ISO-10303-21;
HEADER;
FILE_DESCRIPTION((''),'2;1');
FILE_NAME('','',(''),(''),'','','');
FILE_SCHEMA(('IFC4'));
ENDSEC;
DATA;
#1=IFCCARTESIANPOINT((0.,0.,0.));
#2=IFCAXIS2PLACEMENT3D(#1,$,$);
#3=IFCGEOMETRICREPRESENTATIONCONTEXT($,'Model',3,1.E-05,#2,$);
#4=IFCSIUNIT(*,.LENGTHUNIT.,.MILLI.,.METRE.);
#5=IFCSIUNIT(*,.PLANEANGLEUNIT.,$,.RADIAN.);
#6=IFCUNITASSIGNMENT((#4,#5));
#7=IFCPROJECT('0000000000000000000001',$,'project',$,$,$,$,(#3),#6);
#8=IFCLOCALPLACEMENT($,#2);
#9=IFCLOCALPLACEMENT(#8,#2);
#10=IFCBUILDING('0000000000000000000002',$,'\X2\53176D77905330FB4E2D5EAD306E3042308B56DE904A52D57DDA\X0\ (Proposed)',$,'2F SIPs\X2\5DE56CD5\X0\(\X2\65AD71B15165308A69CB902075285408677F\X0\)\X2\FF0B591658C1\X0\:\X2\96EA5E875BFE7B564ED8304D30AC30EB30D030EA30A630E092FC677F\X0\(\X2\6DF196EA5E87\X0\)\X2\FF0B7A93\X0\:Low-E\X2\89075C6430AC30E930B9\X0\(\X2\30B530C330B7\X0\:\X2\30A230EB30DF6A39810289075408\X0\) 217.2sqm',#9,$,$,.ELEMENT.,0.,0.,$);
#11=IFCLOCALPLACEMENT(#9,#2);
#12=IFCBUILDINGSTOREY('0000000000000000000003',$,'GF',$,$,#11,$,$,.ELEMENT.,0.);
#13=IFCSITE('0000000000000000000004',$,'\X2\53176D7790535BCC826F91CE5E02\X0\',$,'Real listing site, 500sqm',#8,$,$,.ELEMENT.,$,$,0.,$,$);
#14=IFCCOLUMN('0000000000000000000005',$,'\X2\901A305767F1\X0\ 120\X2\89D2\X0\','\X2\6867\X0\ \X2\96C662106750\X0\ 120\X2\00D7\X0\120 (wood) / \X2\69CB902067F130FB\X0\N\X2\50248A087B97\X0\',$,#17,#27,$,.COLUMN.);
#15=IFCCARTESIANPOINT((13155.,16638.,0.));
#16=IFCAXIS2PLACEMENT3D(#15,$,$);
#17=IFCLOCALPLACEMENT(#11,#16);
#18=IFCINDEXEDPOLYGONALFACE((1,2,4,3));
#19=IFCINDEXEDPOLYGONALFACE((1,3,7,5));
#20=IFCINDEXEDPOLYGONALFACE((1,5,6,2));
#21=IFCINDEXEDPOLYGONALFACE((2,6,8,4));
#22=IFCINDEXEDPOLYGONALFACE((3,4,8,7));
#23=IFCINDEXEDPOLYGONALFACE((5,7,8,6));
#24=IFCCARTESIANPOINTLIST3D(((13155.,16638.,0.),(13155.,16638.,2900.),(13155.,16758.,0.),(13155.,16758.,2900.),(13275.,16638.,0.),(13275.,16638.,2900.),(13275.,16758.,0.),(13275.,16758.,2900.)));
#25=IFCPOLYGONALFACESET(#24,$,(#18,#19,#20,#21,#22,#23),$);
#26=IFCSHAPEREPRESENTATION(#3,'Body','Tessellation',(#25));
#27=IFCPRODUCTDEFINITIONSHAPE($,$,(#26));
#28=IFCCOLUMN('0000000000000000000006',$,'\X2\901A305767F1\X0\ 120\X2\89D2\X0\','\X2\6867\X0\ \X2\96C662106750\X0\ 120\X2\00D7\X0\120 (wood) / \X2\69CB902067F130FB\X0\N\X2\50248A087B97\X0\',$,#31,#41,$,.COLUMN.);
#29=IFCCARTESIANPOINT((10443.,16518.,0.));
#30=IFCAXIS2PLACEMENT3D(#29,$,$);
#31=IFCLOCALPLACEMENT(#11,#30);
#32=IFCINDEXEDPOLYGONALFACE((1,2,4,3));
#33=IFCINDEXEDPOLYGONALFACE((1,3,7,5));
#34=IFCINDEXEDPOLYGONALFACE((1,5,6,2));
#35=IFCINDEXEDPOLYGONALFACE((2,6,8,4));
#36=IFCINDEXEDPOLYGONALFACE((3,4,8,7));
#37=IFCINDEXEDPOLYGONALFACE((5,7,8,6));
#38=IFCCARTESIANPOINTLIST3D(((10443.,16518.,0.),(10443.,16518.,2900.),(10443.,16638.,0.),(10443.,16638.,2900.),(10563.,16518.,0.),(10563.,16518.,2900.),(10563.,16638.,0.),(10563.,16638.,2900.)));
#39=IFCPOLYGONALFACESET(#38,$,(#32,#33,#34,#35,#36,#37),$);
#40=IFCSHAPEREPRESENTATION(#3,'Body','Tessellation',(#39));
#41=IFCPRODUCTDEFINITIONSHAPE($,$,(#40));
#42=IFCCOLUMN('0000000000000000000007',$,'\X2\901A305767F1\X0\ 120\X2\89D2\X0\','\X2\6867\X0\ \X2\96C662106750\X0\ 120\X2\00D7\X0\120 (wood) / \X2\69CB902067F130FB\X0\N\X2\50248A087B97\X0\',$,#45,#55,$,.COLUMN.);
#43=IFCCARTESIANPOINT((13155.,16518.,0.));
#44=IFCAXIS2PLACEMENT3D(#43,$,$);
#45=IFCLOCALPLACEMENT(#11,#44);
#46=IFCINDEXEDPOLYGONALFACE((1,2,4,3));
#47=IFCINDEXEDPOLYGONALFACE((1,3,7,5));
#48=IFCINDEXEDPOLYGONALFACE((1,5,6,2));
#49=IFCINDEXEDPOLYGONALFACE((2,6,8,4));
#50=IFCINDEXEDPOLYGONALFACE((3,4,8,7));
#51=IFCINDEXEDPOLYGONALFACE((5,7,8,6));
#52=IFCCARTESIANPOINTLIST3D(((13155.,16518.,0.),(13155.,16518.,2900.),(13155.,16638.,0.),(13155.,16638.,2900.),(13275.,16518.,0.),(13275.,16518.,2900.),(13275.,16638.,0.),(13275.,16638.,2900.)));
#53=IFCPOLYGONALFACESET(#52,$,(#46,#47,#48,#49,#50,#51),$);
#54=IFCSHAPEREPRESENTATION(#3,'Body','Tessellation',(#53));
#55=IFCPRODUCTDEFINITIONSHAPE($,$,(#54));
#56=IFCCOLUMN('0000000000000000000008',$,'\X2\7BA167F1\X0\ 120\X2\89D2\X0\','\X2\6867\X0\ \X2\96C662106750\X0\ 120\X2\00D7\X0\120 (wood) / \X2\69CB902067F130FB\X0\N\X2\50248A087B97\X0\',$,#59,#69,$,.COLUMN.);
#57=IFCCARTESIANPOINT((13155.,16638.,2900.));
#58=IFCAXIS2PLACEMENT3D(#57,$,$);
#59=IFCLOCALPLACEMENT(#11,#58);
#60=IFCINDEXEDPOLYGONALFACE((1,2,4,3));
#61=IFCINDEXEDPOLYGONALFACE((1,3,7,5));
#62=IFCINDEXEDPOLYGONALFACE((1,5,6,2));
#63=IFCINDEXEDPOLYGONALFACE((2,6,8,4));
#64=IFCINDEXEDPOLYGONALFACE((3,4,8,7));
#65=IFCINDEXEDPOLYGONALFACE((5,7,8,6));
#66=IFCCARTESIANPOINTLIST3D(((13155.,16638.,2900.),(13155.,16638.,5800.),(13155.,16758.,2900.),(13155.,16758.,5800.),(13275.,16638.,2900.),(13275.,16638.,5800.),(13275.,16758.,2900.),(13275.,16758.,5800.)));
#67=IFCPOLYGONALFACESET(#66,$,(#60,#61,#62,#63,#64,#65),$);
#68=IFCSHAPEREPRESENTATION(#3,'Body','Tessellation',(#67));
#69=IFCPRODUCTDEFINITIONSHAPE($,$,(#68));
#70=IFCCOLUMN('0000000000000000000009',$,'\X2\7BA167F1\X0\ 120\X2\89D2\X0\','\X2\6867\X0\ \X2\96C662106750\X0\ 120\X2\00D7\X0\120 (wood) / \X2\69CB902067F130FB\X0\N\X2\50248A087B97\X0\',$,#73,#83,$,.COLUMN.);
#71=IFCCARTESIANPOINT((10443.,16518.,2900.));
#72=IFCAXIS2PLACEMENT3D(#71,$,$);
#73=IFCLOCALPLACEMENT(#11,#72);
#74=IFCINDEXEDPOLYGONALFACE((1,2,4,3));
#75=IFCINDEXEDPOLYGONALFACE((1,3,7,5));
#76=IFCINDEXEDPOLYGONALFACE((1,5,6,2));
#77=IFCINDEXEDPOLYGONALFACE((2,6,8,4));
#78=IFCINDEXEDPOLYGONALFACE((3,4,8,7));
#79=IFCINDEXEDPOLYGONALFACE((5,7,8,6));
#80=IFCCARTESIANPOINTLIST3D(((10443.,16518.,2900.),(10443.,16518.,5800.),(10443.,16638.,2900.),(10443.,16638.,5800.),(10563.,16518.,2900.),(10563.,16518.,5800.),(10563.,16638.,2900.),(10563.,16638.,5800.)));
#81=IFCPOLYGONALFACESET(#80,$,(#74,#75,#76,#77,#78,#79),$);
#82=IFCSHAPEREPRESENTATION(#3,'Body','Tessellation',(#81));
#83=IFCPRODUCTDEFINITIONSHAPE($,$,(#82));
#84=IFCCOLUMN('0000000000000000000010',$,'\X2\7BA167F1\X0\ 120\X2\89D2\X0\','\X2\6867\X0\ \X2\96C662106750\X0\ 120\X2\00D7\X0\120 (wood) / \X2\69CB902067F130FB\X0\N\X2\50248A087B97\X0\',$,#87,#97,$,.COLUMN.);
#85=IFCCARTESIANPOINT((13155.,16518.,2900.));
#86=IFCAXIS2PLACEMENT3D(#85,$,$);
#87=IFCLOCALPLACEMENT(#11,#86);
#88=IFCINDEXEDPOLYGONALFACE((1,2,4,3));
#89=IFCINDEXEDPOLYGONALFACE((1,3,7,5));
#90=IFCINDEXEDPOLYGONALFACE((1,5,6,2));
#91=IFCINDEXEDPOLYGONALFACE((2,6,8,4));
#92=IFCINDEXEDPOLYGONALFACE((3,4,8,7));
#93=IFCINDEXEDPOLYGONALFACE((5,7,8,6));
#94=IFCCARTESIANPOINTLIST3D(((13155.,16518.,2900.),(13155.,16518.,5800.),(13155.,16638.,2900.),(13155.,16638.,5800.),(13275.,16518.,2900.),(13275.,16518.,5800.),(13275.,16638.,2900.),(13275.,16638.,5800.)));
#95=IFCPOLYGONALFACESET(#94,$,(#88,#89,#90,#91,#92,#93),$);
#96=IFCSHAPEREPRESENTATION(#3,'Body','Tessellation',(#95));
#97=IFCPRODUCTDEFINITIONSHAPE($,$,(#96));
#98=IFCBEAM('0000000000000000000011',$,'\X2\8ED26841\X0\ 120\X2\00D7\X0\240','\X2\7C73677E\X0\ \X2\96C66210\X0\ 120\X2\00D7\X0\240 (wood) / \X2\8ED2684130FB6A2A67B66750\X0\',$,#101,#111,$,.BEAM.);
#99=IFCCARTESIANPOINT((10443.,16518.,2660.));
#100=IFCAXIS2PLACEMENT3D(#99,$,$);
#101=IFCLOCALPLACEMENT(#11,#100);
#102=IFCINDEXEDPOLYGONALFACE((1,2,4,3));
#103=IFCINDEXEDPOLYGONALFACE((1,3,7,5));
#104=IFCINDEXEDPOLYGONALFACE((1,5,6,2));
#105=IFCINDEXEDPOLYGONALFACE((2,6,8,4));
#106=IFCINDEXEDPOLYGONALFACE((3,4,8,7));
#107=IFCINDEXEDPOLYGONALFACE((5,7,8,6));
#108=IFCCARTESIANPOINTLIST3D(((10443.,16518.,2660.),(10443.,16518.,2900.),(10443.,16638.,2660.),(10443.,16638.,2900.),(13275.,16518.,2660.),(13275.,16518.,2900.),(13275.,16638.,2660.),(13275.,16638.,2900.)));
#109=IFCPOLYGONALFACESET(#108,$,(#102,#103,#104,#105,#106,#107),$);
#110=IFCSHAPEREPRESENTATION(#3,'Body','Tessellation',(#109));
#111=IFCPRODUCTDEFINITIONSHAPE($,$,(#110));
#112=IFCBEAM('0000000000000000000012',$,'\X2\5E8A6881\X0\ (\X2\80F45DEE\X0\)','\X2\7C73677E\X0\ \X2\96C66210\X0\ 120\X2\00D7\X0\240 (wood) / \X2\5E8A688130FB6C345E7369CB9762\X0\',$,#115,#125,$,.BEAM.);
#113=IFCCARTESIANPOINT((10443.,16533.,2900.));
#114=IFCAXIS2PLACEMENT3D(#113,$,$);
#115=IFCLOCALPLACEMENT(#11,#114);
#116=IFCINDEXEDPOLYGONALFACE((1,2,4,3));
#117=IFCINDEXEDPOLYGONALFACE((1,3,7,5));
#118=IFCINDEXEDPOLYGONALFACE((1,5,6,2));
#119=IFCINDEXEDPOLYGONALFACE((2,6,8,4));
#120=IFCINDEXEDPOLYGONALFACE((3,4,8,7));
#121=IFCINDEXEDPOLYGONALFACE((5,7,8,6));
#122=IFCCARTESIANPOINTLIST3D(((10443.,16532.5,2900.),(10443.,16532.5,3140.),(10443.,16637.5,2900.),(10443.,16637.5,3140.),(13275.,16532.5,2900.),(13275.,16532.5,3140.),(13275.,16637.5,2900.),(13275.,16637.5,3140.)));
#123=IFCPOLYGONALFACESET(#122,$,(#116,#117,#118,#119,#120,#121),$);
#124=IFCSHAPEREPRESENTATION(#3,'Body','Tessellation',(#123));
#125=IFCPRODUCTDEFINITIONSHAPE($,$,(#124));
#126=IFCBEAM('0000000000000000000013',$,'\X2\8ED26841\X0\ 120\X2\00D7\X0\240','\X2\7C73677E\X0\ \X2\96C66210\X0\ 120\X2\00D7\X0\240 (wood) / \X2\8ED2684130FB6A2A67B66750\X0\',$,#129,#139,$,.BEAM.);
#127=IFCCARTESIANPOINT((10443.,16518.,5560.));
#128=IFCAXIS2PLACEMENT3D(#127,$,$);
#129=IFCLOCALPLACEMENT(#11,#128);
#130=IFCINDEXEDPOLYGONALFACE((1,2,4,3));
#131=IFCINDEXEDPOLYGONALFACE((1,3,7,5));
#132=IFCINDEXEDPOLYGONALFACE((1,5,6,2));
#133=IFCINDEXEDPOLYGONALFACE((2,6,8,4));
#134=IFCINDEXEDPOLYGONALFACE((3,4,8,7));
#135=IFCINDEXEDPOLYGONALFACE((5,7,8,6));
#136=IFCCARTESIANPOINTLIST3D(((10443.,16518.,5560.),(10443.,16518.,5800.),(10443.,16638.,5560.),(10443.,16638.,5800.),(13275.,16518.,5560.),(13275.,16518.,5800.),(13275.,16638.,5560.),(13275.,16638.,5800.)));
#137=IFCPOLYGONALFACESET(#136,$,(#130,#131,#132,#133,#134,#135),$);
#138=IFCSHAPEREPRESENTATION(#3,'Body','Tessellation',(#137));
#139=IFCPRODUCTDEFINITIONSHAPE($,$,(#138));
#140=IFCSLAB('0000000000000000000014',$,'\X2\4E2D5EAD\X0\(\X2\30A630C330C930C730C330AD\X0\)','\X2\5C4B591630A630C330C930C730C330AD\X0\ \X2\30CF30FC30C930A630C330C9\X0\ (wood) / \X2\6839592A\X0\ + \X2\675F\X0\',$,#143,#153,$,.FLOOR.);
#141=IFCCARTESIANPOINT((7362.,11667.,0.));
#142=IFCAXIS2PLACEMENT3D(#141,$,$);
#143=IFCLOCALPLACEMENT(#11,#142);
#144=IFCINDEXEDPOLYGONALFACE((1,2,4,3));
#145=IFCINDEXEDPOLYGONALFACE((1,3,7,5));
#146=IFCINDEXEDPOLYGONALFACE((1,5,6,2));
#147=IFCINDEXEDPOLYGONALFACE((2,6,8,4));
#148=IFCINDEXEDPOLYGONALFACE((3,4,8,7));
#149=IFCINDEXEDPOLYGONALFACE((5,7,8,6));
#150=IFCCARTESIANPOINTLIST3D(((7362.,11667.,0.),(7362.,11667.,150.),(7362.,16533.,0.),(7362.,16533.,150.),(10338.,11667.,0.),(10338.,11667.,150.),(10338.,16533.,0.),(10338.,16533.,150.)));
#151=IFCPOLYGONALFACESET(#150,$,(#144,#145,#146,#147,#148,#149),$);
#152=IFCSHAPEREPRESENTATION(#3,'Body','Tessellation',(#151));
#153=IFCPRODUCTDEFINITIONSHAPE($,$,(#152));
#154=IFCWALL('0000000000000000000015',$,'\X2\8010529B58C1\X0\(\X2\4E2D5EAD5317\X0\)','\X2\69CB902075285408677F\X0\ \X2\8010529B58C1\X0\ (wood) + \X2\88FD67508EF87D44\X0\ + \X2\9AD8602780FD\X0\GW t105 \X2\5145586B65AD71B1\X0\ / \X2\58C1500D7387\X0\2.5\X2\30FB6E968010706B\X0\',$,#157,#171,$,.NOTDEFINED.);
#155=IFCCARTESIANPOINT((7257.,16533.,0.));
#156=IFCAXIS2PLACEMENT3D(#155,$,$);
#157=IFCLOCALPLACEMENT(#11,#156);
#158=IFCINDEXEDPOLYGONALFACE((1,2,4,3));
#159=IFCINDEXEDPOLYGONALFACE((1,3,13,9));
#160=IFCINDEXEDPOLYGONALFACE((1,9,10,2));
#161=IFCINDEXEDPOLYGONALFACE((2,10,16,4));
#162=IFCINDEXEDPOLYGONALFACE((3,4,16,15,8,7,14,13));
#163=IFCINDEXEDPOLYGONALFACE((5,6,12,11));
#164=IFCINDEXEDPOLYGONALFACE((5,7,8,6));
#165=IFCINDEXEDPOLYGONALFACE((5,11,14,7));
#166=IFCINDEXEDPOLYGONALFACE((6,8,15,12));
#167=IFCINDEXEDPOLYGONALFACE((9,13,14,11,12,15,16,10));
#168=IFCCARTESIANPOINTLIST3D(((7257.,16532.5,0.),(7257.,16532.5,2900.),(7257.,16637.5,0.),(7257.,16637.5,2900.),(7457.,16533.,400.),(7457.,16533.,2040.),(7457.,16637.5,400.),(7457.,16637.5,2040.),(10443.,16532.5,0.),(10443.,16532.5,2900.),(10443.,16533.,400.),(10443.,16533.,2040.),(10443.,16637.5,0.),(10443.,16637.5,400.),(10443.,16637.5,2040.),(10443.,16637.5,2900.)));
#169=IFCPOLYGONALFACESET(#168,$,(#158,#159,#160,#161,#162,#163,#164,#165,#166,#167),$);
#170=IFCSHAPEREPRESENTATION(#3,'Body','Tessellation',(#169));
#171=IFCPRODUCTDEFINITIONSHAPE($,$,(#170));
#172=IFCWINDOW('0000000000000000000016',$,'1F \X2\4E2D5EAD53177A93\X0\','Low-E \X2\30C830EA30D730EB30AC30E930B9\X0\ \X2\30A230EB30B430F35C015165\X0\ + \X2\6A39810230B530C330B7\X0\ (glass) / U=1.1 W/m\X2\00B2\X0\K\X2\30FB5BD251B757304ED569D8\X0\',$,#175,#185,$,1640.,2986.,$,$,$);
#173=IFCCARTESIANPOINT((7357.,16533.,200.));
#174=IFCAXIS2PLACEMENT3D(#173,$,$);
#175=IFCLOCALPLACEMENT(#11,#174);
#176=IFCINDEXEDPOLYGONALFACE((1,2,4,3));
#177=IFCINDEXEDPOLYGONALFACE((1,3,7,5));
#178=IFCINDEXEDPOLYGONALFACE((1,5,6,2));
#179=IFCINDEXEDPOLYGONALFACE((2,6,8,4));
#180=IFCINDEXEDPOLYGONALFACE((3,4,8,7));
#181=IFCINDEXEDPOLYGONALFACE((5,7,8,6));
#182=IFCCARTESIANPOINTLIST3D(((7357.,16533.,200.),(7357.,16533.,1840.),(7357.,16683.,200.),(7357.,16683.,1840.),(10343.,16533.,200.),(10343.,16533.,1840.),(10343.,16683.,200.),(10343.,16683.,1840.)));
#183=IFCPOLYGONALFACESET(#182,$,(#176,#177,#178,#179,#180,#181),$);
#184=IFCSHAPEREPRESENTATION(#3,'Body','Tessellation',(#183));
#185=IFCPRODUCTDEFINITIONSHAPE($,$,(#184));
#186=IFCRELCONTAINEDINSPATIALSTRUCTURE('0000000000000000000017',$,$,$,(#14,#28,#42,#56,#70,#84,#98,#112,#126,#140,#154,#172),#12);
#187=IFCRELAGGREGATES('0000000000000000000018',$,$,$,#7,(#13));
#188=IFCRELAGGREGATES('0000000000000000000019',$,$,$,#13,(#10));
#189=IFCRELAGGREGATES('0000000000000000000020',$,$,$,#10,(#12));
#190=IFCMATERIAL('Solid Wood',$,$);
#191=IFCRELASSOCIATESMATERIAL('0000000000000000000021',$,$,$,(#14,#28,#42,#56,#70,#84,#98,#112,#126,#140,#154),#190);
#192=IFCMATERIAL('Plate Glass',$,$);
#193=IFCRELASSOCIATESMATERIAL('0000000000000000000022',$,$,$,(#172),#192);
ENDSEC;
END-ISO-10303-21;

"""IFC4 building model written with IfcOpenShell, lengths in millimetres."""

from ifc_helpers import new_model, si_unit, frame, frame_2d, origin, place, context, project, spatial, rectangle, extrude, material, element, fill, save


model = new_model("IFC4")

# Units and contexts
model_context = context("Model", 3, precision=1e-05, world=origin())
ifc_project = project(units=[si_unit("LENGTHUNIT", "METRE", prefix="MILLI"), si_unit("PLANEANGLEUNIT", "RADIAN")], contexts=[model_context])

# Site, building, storey
site_placement = place(None, origin())
site = spatial("IfcSite", under=ifc_project, at=site_placement, Name="北海道富良野市", ObjectType="Real listing site, 500sqm", CompositionType="ELEMENT", RefElevation=0.0)
building_placement = place(site_placement, origin())
building = spatial("IfcBuilding", under=site, at=building_placement, Name="北海道・中庭のある回遊動線 (Proposed)", ObjectType="2F SIPs工法(断熱入り構造用合板)＋外壁:雪庇対策付きガルバリウム鋼板(深雪庇)＋窓:Low-E複層ガラス(サッシ:アルミ樹脂複合) 217.2sqm", CompositionType="ELEMENT", ElevationOfRefHeight=0.0, ElevationOfTerrain=0.0)
storey_placement = place(building_placement, origin())
storey = spatial("IfcBuildingStorey", under=building, at=storey_placement, Name="GF", CompositionType="ELEMENT", Elevation=0.0)

# Columns
ifc_material_1 = material(Name="Solid Wood")
column_1_placement = place(storey_placement, frame((13155.0, 16638.0, 0.0)))
element("IfcColumn", 1, at=column_1_placement, inside=storey, material=ifc_material_1, Name="通し柱 120角", Description="桧 集成材 120×120 (wood) / 構造柱・N値計算", PredefinedType="COLUMN", context=model_context, shape_type="SweptSolid", body=[
    extrude(rectangle(XDim=120.0, YDim=120.0, at=frame_2d((60.0, 60.0))), frame((13155.0, 16638.0, 0.0)), (0.0, 0.0, 1.0), 2900.0),
])
column_2_placement = place(storey_placement, frame((10443.0, 16518.0, 0.0)))
element("IfcColumn", 2, at=column_2_placement, inside=storey, material=ifc_material_1, Name="通し柱 120角", Description="桧 集成材 120×120 (wood) / 構造柱・N値計算", PredefinedType="COLUMN", context=model_context, shape_type="SweptSolid", body=[
    extrude(rectangle(XDim=120.0, YDim=120.0, at=frame_2d((60.0, 60.0))), frame((10443.0, 16518.0, 0.0)), (0.0, 0.0, 1.0), 2900.0),
])
column_3_placement = place(storey_placement, frame((13155.0, 16518.0, 0.0)))
element("IfcColumn", 3, at=column_3_placement, inside=storey, material=ifc_material_1, Name="通し柱 120角", Description="桧 集成材 120×120 (wood) / 構造柱・N値計算", PredefinedType="COLUMN", context=model_context, shape_type="SweptSolid", body=[
    extrude(rectangle(XDim=120.0, YDim=120.0, at=frame_2d((60.0, 60.0))), frame((13155.0, 16518.0, 0.0)), (0.0, 0.0, 1.0), 2900.0),
])
column_4_placement = place(storey_placement, frame((13155.0, 16638.0, 2900.0)))
element("IfcColumn", 4, at=column_4_placement, inside=storey, material=ifc_material_1, Name="管柱 120角", Description="桧 集成材 120×120 (wood) / 構造柱・N値計算", PredefinedType="COLUMN", context=model_context, shape_type="SweptSolid", body=[
    extrude(rectangle(XDim=120.0, YDim=120.0, at=frame_2d((60.0, 60.0))), frame((13155.0, 16638.0, 2900.0)), (0.0, 0.0, 1.0), 2900.0),
])
column_5_placement = place(storey_placement, frame((10443.0, 16518.0, 2900.0)))
element("IfcColumn", 5, at=column_5_placement, inside=storey, material=ifc_material_1, Name="管柱 120角", Description="桧 集成材 120×120 (wood) / 構造柱・N値計算", PredefinedType="COLUMN", context=model_context, shape_type="SweptSolid", body=[
    extrude(rectangle(XDim=120.0, YDim=120.0, at=frame_2d((60.0, 60.0))), frame((10443.0, 16518.0, 2900.0)), (0.0, 0.0, 1.0), 2900.0),
])
column_6_placement = place(storey_placement, frame((13155.0, 16518.0, 2900.0)))
element("IfcColumn", 6, at=column_6_placement, inside=storey, material=ifc_material_1, Name="管柱 120角", Description="桧 集成材 120×120 (wood) / 構造柱・N値計算", PredefinedType="COLUMN", context=model_context, shape_type="SweptSolid", body=[
    extrude(rectangle(XDim=120.0, YDim=120.0, at=frame_2d((60.0, 60.0))), frame((13155.0, 16518.0, 2900.0)), (0.0, 0.0, 1.0), 2900.0),
])

# Beams
beam_1_placement = place(storey_placement, frame((10443.0, 16518.0, 2660.0)))
element("IfcBeam", 7, at=beam_1_placement, inside=storey, material=ifc_material_1, Name="軒桁 120×240", Description="米松 集成 120×240 (wood) / 軒桁・横架材", PredefinedType="BEAM", context=model_context, shape_type="SweptSolid", body=[
    extrude(rectangle(XDim=2832.0, YDim=120.0, at=frame_2d((1416.0, 60.0))), frame((10443.0, 16518.0, 2660.0)), (0.0, 0.0, 1.0), 240.0),
])
beam_2_placement = place(storey_placement, frame((10443.0, 16533.0, 2900.0)))
element("IfcBeam", 8, at=beam_2_placement, inside=storey, material=ifc_material_1, Name="床梁 (胴差)", Description="米松 集成 120×240 (wood) / 床梁・水平構面", PredefinedType="BEAM", context=model_context, shape_type="SweptSolid", body=[
    extrude(rectangle(XDim=2832.0, YDim=105.0, at=frame_2d((1416.0, 52.0))), frame((10443.0, 16533.0, 2900.0)), (0.0, 0.0, 1.0), 240.0),
])
beam_3_placement = place(storey_placement, frame((10443.0, 16518.0, 5560.0)))
element("IfcBeam", 9, at=beam_3_placement, inside=storey, material=ifc_material_1, Name="軒桁 120×240", Description="米松 集成 120×240 (wood) / 軒桁・横架材", PredefinedType="BEAM", context=model_context, shape_type="SweptSolid", body=[
    extrude(rectangle(XDim=2832.0, YDim=120.0, at=frame_2d((1416.0, 60.0))), frame((10443.0, 16518.0, 5560.0)), (0.0, 0.0, 1.0), 240.0),
])

# Slab
slab_placement = place(storey_placement, frame((7362.0, 11667.0, 0.0)))
element("IfcSlab", 10, at=slab_placement, inside=storey, material=ifc_material_1, Name="中庭(ウッドデッキ)", Description="屋外ウッドデッキ ハードウッド (wood) / 根太 + 束", PredefinedType="FLOOR", context=model_context, shape_type="SweptSolid", body=[
    extrude(rectangle(XDim=2976.0, YDim=4866.0, at=frame_2d((1488.0, 2433.0))), frame((7362.0, 11667.0, 0.0)), (0.0, 0.0, 1.0), 150.0),
])

# Wall, opening, window
wall_1_placement = place(storey_placement, frame((7257.0, 16533.0, 0.0)))
wall_1 = element("IfcWall", 11, at=wall_1_placement, inside=storey, material=ifc_material_1, Name="耐力壁(中庭北)", Description="構造用合板 耐力壁 (wood) + 製材軸組 + 高性能GW t105 充填断熱 / 壁倍率2.5・準耐火", PredefinedType="NOTDEFINED", context=model_context, shape_type="SweptSolid", body=[
    extrude(rectangle(XDim=3186.0, YDim=105.0, at=frame_2d((1593.0, 52.0))), frame((7257.0, 16533.0, 0.0)), (0.0, 0.0, 1.0), 2900.0),
])
opening_1_placement = place(storey_placement, frame((7357.0, 16533.0, 200.0)))
opening_1 = element("IfcOpeningElement", 12, at=opening_1_placement, cuts=wall_1, PredefinedType="NOTDEFINED", context=model_context, shape_type="SweptSolid", body=[
    extrude(rectangle(XDim=2986.0, YDim=150.0, at=frame_2d((1493.0, 75.0))), frame((7357.0, 16533.0, 200.0)), (0.0, 0.0, 1.0), 1640.0),
])
ifc_material_2 = material(Name="Plate Glass")
window_1_placement = place(storey_placement, frame((7357.0, 16533.0, 200.0)))
window_1 = element("IfcWindow", 13, at=window_1_placement, inside=storey, material=ifc_material_2, Name="1F 中庭北窓", Description="Low-E トリプルガラス アルゴン封入 + 樹脂サッシ (glass) / U=1.1 W/m²K・寒冷地仕様", OverallHeight=1640.0, OverallWidth=2986.0, context=model_context, shape_type="SweptSolid", body=[
    extrude(rectangle(XDim=2986.0, YDim=150.0, at=frame_2d((1493.0, 75.0))), frame((7357.0, 16533.0, 200.0)), (0.0, 0.0, 1.0), 1640.0),
])
fill(opening_1, window_1)

save(model, "model.ifc")
